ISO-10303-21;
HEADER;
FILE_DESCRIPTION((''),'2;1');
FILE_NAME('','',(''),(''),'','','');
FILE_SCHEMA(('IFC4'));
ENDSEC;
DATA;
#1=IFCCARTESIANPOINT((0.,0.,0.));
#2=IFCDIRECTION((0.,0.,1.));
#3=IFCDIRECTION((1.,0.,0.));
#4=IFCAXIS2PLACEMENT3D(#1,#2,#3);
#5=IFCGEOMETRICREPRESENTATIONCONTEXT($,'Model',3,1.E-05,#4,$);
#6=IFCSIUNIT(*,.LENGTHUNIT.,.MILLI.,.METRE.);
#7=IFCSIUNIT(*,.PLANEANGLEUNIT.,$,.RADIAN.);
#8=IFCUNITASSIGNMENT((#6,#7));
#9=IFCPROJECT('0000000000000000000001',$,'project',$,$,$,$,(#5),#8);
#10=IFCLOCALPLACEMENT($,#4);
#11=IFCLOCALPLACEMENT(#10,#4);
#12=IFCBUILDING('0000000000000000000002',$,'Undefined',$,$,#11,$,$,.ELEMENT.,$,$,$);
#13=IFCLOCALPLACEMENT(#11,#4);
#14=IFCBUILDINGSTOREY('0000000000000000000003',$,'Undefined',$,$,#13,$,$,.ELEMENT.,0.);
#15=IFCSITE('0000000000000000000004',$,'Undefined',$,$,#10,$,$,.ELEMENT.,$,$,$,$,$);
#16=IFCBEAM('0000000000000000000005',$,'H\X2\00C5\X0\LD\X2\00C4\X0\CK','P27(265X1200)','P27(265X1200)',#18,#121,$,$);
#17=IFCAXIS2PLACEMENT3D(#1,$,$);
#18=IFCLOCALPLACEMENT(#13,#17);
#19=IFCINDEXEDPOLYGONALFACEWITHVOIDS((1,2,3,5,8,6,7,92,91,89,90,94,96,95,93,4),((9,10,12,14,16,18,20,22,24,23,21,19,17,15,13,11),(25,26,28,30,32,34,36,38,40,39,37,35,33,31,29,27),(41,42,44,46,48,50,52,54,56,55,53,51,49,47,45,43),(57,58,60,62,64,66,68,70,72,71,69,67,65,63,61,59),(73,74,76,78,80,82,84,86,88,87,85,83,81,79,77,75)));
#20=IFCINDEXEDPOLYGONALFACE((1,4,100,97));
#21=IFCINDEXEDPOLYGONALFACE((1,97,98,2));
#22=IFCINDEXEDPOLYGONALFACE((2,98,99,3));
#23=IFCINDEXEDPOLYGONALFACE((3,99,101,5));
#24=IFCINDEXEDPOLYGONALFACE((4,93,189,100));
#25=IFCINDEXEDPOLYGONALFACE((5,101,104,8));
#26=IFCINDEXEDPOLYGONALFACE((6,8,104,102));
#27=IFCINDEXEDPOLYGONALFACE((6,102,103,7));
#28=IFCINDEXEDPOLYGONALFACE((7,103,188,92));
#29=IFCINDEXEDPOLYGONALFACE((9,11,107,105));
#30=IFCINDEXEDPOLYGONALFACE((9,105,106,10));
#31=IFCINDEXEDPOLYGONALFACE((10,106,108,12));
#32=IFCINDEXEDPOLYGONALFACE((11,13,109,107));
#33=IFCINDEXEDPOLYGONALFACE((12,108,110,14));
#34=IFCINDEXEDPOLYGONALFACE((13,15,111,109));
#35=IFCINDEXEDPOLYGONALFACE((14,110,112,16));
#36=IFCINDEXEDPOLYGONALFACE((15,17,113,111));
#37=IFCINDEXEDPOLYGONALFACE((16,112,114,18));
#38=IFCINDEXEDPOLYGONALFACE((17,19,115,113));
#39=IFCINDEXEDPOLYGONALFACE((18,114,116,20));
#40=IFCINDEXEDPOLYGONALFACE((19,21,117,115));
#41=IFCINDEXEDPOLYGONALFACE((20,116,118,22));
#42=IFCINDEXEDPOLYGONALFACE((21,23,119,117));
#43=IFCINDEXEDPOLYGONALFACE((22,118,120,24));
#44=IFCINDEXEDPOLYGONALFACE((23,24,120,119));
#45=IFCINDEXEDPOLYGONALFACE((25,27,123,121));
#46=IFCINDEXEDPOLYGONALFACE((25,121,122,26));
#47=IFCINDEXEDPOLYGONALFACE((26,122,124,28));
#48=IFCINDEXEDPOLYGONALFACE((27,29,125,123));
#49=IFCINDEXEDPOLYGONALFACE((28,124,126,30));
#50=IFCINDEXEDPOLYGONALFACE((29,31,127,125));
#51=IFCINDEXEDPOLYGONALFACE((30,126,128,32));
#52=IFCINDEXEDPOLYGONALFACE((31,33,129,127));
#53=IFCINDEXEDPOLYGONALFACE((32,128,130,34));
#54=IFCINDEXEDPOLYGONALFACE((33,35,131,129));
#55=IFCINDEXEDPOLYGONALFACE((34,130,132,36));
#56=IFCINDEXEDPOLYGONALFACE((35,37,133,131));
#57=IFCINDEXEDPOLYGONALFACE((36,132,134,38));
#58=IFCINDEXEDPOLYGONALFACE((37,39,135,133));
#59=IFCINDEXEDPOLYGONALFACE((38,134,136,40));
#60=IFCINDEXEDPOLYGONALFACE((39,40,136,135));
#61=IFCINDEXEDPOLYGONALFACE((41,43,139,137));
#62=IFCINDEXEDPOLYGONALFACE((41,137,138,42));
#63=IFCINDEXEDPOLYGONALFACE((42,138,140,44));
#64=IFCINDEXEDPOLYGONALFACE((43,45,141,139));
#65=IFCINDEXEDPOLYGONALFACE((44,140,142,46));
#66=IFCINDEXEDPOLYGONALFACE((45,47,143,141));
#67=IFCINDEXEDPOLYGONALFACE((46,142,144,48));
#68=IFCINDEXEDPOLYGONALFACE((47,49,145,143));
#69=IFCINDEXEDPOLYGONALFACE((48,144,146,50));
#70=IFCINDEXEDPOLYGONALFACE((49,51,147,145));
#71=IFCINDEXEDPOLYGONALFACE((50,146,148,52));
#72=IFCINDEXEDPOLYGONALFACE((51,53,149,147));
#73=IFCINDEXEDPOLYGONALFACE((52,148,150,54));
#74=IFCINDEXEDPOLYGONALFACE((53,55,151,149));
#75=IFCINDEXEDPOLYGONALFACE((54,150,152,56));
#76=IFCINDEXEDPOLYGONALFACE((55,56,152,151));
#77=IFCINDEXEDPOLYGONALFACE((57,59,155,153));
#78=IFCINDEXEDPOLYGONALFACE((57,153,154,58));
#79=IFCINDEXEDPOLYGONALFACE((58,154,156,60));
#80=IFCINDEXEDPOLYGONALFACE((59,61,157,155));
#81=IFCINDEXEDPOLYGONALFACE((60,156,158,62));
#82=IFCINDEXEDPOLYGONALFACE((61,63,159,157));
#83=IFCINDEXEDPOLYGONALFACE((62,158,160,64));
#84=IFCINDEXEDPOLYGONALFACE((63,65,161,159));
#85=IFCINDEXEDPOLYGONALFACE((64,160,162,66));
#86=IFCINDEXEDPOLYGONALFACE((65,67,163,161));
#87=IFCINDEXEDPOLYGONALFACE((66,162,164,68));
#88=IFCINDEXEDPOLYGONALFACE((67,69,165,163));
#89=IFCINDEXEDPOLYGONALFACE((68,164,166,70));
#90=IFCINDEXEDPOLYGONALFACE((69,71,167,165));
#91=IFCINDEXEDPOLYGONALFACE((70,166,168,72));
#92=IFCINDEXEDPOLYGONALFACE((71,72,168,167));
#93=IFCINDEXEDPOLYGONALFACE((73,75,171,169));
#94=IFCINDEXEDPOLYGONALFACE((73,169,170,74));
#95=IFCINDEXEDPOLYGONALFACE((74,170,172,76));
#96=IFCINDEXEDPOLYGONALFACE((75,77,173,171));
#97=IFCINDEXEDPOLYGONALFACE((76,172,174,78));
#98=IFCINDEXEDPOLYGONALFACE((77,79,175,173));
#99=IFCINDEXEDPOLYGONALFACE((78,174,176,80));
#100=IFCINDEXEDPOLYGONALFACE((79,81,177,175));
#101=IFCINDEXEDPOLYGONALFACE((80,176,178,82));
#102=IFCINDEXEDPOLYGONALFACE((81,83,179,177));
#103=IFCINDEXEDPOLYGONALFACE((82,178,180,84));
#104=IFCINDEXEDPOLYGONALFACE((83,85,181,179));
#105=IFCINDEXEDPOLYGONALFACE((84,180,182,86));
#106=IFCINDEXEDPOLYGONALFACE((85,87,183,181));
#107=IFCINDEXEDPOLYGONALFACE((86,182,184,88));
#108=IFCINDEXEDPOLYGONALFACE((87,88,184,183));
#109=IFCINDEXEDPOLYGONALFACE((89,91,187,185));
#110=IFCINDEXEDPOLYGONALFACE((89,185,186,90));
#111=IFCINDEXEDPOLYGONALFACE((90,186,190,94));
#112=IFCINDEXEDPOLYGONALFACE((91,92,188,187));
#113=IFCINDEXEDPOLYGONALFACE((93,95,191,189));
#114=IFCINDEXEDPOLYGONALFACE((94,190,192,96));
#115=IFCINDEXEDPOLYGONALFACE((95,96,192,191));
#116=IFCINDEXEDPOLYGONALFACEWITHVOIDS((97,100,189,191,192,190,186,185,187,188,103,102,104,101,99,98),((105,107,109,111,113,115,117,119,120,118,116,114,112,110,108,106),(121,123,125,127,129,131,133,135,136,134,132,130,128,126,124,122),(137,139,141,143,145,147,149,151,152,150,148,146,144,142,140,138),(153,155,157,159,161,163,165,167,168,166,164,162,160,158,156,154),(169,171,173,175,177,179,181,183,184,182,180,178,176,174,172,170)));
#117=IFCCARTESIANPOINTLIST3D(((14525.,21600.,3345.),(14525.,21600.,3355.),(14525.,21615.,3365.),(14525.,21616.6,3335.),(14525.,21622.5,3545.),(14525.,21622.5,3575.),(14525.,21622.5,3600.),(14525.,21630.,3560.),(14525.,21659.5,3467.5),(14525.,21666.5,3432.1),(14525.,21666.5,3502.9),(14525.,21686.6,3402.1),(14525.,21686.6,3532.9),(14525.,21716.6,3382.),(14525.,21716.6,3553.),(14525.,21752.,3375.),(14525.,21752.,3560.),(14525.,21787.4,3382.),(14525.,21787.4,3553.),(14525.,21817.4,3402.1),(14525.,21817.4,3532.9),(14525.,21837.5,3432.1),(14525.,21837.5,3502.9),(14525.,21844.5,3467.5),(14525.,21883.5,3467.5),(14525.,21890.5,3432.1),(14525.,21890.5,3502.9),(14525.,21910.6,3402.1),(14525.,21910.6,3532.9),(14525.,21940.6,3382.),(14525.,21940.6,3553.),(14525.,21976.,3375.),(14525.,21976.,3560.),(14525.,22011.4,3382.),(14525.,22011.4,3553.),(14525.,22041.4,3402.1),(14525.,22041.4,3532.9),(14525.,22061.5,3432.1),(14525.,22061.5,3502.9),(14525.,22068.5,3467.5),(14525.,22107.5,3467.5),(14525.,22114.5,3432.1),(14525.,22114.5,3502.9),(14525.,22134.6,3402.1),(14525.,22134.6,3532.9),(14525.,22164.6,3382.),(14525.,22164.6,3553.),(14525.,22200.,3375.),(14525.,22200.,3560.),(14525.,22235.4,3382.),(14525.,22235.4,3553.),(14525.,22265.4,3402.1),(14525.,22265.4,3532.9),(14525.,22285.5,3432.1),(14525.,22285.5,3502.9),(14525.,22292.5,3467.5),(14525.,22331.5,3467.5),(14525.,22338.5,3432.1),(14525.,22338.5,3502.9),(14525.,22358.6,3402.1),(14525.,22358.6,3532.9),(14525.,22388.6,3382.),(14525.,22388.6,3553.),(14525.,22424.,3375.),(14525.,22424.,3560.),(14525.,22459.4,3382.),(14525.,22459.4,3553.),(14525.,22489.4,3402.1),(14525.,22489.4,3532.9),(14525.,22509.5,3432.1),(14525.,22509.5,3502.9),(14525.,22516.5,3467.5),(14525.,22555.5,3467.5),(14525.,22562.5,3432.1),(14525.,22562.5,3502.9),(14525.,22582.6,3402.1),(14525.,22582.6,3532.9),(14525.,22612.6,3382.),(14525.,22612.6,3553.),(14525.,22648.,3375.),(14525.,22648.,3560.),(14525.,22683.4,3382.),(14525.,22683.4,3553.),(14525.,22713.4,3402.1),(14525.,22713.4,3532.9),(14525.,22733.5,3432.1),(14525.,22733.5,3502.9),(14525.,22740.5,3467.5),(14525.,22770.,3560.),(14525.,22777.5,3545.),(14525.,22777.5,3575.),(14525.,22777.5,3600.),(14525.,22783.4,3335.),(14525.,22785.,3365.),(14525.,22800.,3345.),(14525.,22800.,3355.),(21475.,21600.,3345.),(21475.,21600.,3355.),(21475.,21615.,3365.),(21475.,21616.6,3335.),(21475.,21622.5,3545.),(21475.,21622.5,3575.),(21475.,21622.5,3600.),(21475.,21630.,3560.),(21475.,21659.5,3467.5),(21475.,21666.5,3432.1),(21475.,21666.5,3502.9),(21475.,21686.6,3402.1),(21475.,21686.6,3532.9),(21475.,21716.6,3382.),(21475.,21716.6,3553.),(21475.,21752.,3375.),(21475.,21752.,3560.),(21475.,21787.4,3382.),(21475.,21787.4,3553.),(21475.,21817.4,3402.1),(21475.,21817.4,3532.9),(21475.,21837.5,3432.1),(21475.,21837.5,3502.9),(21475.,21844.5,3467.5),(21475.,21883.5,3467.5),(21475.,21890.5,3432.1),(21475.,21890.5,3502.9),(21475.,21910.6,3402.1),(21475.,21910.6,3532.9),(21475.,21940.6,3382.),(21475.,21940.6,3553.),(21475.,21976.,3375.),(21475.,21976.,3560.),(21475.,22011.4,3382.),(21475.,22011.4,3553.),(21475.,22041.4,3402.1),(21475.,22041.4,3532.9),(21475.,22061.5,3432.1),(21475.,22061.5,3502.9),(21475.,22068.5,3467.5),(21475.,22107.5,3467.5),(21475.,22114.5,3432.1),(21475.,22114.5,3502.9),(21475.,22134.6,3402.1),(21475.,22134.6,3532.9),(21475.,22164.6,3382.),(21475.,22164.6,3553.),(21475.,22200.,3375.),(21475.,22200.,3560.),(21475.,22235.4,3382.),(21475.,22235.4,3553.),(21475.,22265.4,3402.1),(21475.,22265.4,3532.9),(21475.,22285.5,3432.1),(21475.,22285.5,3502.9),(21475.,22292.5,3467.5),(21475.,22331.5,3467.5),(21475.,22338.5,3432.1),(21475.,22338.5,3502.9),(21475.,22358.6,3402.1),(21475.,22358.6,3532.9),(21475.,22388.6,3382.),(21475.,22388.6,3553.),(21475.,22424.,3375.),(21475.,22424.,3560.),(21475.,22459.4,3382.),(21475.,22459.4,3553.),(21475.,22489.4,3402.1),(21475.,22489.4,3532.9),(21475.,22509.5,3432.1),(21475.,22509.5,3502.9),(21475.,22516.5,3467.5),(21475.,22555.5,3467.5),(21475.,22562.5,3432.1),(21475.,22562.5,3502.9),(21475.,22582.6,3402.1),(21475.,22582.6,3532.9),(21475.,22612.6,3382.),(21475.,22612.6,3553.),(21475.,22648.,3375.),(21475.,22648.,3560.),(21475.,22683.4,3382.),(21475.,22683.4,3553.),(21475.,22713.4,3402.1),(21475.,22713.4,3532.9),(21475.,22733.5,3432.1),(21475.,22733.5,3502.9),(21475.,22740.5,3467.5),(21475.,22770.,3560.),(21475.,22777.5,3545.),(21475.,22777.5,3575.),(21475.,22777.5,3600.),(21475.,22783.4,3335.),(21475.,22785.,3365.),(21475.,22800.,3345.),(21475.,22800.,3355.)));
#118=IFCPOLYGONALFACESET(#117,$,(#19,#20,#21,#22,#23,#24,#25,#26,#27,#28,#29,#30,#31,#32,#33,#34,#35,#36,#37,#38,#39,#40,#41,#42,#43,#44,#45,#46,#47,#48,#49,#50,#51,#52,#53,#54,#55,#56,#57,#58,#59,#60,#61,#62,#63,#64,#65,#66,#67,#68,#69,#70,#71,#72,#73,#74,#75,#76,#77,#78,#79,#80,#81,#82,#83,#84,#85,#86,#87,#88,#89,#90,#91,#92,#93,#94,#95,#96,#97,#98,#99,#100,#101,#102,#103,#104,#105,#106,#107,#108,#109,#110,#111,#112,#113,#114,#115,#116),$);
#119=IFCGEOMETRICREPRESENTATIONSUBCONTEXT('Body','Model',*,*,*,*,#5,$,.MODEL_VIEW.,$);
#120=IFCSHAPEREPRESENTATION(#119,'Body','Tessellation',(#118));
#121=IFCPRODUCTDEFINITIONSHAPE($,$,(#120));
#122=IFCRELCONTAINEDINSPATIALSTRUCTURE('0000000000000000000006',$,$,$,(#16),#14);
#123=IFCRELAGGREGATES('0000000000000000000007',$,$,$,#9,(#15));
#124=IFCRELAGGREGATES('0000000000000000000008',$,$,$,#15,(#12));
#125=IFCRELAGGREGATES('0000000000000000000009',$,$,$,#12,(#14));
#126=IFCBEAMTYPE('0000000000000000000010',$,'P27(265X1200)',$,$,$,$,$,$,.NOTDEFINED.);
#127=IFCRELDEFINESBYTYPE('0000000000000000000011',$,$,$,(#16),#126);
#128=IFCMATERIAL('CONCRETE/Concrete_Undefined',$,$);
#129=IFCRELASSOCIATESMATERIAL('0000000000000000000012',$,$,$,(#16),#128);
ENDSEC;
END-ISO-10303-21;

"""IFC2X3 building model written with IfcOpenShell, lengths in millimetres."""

from ifc_helpers import new_model, si_unit, frame, origin_with_axes, place, context, subcontext, project, spatial, polyline, outline, extrude, material, type_object, element, save


model = new_model("IFC2X3")

# Units and contexts
model_context = context("Model", 3, precision=1e-05, world=origin_with_axes())
body_context = subcontext(model_context, "Body", "Model", "MODEL_VIEW")
ifc_project = project(units=[si_unit("LENGTHUNIT", "METRE", prefix="MILLI"), si_unit("PLANEANGLEUNIT", "RADIAN")], contexts=[model_context])

# Site, building, storey
site_placement = place(None, origin_with_axes())
site = spatial("IfcSite", under=ifc_project, at=site_placement, Name="Undefined", CompositionType="ELEMENT")
building_placement = place(site_placement, origin_with_axes())
building = spatial("IfcBuilding", under=site, at=building_placement, Name="Undefined", CompositionType="ELEMENT")
storey_placement = place(building_placement, origin_with_axes())
storey = spatial("IfcBuildingStorey", under=building, at=storey_placement, Name="Undefined", CompositionType="ELEMENT", Elevation=0.0)

# Beam
ifc_material_1 = material(Name="CONCRETE/Concrete_Undefined")
beam_type_1 = type_object("IfcBeamType", Name="P27(265X1200)", PredefinedType="NOTDEFINED")
beam_1_placement = place(storey_placement, frame((14525.0, 22200.0, 3467.5), z_axis=(0.0, 0.0, 1.0), x_axis=(1.0, 0.0, 0.0)))
element("IfcBeam", 1, at=beam_1_placement, inside=storey, type_object=beam_type_1, material=ifc_material_1, Name="HÅLDÄCK", Description="P27(265X1200)", ObjectType="P27(265X1200)", context=body_context, shape_type="SweptSolid", body=[
    extrude(outline(polyline([(-583.4, -132.5), (-600.0, -122.5), (-600.0, -112.5), (-585.0, -102.5), (-577.5, 77.5), (-570.0, 92.5), (-577.5, 107.5), (-577.5, 132.5), (577.5, 132.5), (577.5, 107.5), (570.0, 92.5), (577.5, 77.5), (585.0, -102.5), (600.0, -112.5), (600.0, -122.5), (583.4, -132.5), (-583.4, -132.5)]), holes=[polyline([(-513.4, 65.4), (-533.5, 35.4), (-540.5, 0.0), (-533.5, -35.4), (-513.4, -65.4), (-483.4, -85.5), (-448.0, -92.5), (-412.6, -85.5), (-382.6, -65.4), (-362.5, -35.4), (-355.5, 0.0), (-362.5, 35.4), (-382.6, 65.4), (-412.6, 85.5), (-448.0, 92.5), (-483.4, 85.5), (-513.4, 65.4)]), polyline([(-289.4, 65.4), (-309.5, 35.4), (-316.5, 0.0), (-309.5, -35.4), (-289.4, -65.4), (-259.4, -85.5), (-224.0, -92.5), (-188.6, -85.5), (-158.6, -65.4), (-138.5, -35.4), (-131.5, 0.0), (-138.5, 35.4), (-158.6, 65.4), (-188.6, 85.5), (-224.0, 92.5), (-259.4, 85.5), (-289.4, 65.4)]), polyline([(-65.4, 65.4), (-85.5, 35.4), (-92.5, 0.0), (-85.5, -35.4), (-65.4, -65.4), (-35.4, -85.5), (0.0, -92.5), (35.4, -85.5), (65.4, -65.4), (85.5, -35.4), (92.5, 0.0), (85.5, 35.4), (65.4, 65.4), (35.4, 85.5), (0.0, 92.5), (-35.4, 85.5), (-65.4, 65.4)]), polyline([(158.6, 65.4), (138.5, 35.4), (131.5, 0.0), (138.5, -35.4), (158.6, -65.4), (188.6, -85.5), (224.0, -92.5), (259.4, -85.5), (289.4, -65.4), (309.5, -35.4), (316.5, 0.0), (309.5, 35.4), (289.4, 65.4), (259.4, 85.5), (224.0, 92.5), (188.6, 85.5), (158.6, 65.4)]), polyline([(382.6, 65.4), (362.5, 35.4), (355.5, 0.0), (362.5, -35.4), (382.6, -65.4), (412.6, -85.5), (448.0, -92.5), (483.4, -85.5), (513.4, -65.4), (533.5, -35.4), (540.5, 0.0), (533.5, 35.4), (513.4, 65.4), (483.4, 85.5), (448.0, 92.5), (412.6, 85.5), (382.6, 65.4)])]), frame((6950.0, 0.0, 0.0), z_axis=(-1.0, 0.0, 0.0), x_axis=(0.0, -1.0, 0.0)), (0.0, 0.0, 1.0), 6950.0),
])

save(model, "model.ifc")
